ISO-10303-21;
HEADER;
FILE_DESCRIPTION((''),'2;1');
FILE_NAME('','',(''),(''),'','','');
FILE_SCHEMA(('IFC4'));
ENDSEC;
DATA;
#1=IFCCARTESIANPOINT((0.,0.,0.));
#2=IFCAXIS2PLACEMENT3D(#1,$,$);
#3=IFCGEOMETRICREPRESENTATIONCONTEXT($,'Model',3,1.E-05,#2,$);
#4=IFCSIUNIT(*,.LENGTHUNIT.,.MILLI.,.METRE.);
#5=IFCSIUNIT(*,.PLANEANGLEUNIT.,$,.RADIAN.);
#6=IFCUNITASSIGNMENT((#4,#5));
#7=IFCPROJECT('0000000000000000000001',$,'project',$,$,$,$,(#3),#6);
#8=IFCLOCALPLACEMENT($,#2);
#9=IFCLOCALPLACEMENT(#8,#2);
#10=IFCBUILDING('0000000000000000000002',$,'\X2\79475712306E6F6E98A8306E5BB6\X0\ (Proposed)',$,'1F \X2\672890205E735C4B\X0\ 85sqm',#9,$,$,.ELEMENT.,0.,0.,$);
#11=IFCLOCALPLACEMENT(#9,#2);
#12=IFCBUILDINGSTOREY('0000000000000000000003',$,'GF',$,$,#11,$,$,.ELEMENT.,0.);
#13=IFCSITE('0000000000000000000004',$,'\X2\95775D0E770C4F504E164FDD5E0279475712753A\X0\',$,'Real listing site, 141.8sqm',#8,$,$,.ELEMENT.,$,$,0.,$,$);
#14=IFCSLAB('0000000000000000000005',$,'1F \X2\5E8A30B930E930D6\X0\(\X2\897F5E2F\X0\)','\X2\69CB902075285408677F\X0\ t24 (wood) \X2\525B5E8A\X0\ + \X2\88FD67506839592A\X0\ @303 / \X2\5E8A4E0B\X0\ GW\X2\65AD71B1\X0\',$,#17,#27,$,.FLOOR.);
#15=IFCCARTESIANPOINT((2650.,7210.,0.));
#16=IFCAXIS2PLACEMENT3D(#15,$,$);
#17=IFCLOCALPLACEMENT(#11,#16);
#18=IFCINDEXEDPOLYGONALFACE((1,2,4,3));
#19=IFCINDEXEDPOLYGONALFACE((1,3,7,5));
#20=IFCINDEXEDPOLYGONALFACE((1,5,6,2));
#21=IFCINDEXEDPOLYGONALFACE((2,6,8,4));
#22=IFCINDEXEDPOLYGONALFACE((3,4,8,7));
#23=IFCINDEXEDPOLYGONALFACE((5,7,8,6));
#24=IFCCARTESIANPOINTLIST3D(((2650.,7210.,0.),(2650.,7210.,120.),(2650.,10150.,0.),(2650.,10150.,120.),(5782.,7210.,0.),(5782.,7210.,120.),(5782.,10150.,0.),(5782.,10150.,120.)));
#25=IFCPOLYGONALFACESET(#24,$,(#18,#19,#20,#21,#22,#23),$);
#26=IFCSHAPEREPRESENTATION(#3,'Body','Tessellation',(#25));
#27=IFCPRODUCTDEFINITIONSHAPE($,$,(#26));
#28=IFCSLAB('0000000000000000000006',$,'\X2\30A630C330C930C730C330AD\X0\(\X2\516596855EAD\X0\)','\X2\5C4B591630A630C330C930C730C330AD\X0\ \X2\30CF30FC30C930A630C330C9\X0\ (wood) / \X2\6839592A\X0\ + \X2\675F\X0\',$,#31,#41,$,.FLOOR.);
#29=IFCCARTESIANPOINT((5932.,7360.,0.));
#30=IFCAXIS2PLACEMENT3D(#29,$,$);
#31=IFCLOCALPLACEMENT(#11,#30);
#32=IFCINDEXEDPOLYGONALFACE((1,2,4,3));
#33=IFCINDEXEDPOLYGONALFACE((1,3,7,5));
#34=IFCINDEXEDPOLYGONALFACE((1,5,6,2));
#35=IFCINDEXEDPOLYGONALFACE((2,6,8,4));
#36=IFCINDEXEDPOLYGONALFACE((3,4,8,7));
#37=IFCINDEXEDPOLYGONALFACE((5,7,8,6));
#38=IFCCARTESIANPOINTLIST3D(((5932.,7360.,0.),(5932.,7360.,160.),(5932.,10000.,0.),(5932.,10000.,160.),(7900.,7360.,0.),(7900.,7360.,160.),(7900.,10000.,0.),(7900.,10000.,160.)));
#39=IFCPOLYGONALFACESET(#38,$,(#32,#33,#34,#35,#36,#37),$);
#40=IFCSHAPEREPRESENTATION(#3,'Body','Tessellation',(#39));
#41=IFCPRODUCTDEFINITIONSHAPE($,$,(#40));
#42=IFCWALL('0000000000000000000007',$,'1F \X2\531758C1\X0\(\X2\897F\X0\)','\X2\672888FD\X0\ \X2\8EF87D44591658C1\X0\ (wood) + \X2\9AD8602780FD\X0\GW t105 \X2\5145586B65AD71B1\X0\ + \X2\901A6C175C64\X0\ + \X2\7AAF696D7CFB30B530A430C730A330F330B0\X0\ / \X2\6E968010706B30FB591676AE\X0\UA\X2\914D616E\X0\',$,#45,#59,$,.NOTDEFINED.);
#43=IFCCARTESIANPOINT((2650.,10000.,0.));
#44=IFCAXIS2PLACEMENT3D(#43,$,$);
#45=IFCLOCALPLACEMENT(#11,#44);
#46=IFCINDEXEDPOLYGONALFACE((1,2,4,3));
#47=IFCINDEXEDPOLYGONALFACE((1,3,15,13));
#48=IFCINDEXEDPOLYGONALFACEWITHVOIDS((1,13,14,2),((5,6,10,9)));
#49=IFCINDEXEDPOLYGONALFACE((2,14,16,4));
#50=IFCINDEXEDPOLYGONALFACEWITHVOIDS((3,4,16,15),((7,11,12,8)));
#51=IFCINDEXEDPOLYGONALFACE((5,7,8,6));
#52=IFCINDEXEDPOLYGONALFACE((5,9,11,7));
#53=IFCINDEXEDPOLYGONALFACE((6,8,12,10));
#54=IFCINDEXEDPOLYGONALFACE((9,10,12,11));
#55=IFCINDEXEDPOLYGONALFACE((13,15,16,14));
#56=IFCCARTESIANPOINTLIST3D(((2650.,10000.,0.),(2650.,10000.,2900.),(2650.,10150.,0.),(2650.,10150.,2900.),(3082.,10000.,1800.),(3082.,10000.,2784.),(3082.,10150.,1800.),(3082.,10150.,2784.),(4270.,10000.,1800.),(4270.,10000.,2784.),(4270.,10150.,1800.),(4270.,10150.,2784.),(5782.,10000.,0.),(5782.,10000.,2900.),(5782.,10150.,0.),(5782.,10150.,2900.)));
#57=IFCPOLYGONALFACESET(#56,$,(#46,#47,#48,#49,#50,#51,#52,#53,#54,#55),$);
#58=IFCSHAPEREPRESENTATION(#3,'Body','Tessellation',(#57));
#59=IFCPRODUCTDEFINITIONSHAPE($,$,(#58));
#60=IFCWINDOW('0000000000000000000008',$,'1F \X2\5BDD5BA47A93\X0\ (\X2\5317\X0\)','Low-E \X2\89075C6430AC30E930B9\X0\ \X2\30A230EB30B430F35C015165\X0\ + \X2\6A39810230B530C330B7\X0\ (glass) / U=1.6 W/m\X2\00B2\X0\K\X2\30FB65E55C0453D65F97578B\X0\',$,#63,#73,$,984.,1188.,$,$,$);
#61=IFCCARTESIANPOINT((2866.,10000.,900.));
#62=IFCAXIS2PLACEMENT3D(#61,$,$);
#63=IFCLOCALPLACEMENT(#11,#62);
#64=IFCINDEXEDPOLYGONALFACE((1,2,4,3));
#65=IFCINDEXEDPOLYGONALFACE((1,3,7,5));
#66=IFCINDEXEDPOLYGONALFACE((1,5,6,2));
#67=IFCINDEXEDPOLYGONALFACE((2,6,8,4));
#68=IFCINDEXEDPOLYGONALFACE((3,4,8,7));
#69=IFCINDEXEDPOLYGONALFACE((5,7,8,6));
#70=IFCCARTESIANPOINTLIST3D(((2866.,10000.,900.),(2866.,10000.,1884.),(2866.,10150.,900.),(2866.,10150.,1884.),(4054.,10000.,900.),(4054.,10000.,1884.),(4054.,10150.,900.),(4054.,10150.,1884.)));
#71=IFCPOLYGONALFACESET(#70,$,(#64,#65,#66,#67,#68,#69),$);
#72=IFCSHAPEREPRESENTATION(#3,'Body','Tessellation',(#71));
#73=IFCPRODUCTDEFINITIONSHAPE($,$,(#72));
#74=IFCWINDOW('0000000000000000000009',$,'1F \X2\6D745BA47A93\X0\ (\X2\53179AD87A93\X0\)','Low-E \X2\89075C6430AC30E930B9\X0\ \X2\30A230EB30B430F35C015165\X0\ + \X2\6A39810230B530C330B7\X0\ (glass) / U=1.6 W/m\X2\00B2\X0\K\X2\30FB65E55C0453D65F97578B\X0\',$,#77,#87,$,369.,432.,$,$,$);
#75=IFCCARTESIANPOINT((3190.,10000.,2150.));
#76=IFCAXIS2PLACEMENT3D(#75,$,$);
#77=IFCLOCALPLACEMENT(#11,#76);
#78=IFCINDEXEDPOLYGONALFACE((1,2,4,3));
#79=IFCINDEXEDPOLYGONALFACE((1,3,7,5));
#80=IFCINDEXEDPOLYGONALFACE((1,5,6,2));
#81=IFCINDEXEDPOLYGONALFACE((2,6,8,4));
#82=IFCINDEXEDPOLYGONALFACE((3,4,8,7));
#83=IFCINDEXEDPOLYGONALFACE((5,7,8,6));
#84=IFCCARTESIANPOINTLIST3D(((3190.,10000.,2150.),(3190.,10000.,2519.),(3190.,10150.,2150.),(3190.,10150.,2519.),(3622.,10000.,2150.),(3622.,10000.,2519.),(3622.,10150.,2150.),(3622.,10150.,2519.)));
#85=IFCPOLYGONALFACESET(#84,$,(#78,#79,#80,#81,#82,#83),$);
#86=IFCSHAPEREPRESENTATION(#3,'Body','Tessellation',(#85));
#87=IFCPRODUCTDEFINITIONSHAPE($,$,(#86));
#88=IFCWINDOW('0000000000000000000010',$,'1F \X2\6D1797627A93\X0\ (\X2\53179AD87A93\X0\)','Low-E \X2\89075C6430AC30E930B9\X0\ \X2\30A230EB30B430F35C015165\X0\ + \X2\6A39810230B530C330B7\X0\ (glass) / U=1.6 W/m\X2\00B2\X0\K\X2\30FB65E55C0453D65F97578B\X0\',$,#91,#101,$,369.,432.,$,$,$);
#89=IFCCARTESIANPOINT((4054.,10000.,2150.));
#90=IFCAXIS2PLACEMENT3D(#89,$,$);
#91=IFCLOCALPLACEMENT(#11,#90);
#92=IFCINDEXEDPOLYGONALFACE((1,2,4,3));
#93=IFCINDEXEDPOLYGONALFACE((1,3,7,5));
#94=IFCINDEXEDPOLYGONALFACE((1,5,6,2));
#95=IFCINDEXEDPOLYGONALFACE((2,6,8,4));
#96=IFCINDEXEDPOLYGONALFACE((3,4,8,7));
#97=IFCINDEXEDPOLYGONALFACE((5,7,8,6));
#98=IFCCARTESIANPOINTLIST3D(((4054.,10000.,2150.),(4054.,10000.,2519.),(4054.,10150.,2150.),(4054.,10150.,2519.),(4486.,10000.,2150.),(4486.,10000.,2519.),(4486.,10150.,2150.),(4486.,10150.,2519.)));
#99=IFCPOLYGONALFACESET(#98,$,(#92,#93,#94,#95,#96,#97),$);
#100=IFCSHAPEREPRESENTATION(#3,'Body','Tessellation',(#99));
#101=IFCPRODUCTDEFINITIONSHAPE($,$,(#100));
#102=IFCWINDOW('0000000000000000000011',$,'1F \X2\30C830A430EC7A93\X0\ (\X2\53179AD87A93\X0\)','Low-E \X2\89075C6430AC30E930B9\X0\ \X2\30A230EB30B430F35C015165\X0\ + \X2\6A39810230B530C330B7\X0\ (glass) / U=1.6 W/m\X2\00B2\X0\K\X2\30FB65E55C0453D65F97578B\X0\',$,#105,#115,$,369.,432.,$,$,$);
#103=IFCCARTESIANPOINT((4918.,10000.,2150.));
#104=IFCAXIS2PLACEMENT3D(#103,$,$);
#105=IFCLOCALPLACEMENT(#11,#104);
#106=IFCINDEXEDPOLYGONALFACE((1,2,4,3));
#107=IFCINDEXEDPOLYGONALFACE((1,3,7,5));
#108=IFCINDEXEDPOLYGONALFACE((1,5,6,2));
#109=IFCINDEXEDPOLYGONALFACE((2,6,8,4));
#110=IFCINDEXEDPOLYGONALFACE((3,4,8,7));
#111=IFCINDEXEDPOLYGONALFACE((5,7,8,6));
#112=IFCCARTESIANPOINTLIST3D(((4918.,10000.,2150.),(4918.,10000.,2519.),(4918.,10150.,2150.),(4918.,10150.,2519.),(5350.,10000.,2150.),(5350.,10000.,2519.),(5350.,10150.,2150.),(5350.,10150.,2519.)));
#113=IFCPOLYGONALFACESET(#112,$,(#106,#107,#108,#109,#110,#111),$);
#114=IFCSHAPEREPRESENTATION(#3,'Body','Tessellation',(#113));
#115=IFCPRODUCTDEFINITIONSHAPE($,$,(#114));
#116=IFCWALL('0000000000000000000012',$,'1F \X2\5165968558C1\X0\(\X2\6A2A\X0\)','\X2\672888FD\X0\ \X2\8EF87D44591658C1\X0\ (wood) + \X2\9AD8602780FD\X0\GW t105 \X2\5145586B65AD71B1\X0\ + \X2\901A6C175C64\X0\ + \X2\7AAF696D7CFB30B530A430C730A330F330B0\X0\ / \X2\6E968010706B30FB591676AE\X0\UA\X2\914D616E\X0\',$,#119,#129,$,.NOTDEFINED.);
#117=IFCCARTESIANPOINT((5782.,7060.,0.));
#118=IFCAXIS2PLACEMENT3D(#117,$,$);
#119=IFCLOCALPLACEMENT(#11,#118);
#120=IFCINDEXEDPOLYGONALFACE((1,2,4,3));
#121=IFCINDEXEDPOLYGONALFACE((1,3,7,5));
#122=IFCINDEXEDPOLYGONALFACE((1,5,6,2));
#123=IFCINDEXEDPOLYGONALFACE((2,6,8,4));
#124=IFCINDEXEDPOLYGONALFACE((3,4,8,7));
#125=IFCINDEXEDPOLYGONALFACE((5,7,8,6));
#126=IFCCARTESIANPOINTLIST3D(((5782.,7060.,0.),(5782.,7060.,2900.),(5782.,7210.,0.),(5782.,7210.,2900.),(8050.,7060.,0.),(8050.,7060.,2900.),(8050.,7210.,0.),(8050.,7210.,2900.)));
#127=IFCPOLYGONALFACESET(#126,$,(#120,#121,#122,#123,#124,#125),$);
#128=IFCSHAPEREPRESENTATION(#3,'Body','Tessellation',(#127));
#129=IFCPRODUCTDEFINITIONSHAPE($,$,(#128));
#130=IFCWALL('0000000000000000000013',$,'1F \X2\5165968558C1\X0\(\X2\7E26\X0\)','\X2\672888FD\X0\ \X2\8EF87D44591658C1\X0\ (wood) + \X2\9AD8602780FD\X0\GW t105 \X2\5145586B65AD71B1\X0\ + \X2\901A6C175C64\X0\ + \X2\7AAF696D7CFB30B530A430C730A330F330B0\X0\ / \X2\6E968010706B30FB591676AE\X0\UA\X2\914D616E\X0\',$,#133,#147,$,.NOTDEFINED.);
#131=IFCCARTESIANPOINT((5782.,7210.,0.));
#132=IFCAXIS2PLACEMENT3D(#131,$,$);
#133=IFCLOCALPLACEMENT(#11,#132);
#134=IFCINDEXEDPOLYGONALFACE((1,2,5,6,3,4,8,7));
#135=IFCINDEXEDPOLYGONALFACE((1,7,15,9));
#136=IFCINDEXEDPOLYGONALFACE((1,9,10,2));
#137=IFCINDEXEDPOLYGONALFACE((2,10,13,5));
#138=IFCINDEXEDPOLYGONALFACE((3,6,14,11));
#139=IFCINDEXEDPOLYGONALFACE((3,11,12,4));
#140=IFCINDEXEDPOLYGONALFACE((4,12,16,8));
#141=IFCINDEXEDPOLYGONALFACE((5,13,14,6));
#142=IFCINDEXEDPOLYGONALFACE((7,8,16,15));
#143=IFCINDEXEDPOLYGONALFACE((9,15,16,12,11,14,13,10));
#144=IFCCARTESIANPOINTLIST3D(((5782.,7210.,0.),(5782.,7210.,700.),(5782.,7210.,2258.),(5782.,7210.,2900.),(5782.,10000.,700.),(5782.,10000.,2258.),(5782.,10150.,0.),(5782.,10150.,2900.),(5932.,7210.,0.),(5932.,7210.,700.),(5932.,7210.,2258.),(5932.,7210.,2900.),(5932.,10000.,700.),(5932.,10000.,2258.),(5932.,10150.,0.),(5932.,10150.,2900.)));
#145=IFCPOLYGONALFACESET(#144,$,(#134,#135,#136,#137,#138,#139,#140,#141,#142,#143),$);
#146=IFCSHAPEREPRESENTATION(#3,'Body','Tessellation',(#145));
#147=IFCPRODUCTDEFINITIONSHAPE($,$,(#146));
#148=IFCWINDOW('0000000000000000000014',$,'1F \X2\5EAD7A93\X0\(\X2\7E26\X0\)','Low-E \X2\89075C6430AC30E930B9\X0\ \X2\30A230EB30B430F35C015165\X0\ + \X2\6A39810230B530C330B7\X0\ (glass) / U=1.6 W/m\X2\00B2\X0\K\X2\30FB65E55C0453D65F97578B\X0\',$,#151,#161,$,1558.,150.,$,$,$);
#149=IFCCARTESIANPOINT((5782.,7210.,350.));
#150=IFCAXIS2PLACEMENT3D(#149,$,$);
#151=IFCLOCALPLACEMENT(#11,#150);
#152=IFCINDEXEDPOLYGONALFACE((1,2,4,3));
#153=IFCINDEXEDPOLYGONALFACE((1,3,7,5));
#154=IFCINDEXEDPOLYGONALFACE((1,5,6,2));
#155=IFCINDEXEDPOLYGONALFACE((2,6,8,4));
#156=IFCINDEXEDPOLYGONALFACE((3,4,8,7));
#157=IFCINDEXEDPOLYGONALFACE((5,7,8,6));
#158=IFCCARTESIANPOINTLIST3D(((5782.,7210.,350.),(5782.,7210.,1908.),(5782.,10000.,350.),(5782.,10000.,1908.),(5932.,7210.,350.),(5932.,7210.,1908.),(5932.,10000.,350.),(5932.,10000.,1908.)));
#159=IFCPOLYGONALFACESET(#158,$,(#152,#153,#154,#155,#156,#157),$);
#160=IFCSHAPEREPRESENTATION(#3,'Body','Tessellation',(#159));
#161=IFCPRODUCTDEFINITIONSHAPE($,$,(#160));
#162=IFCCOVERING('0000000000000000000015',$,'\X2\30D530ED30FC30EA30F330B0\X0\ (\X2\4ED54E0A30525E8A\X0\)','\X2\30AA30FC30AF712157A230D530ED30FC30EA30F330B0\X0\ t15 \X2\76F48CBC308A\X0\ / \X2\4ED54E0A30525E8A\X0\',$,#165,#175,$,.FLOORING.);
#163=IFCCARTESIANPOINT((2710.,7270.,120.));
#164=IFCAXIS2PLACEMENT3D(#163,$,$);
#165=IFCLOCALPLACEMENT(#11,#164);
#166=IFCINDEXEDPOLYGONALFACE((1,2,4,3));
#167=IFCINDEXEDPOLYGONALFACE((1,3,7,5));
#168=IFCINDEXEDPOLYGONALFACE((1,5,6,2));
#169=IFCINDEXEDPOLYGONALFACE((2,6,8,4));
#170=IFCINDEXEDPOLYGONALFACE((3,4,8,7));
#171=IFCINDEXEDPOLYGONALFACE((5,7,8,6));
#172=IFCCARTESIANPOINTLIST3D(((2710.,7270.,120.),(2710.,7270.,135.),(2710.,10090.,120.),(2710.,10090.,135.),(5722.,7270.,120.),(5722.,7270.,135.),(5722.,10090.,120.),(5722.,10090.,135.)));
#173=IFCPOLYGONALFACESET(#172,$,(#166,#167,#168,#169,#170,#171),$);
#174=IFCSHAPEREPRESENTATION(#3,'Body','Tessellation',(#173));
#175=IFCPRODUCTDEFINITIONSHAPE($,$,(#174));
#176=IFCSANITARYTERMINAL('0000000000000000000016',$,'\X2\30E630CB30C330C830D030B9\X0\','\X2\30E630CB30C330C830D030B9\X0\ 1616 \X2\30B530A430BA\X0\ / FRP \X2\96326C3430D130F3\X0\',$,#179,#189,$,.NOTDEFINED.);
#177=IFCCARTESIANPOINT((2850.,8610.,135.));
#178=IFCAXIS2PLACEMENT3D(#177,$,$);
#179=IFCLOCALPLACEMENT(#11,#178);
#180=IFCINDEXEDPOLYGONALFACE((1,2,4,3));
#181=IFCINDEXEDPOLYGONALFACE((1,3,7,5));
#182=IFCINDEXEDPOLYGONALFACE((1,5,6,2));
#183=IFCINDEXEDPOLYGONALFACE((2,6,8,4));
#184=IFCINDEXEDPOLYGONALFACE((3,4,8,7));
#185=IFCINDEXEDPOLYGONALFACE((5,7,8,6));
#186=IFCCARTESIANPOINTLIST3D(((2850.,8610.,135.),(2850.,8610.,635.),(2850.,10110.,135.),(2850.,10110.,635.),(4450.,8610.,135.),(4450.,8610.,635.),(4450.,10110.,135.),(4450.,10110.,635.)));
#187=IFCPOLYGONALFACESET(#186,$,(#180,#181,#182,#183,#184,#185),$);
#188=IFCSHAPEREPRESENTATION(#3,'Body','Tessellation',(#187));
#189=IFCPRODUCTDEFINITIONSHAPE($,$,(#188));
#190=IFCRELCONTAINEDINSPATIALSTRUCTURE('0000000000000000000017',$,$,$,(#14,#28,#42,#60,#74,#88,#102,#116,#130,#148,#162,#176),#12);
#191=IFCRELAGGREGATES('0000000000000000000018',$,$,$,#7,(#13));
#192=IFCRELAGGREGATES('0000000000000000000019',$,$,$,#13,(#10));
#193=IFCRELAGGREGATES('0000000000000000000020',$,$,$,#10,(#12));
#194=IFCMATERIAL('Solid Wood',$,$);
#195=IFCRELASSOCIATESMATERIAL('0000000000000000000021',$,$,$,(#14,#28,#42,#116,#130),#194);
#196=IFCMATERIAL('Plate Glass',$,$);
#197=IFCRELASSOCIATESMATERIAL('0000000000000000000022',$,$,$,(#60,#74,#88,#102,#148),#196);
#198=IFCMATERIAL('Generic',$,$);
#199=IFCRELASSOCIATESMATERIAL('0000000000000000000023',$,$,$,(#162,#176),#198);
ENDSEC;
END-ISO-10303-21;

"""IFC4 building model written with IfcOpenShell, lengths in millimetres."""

from ifc_helpers import new_model, si_unit, frame, frame_2d, origin, place, context, project, spatial, rectangle, extrude, material, element, fill, save


model = new_model("IFC4")

# Units and contexts
model_context = context("Model", 3, precision=1e-05, world=origin())
ifc_project = project(units=[si_unit("LENGTHUNIT", "METRE", prefix="MILLI"), si_unit("PLANEANGLEUNIT", "RADIAN")], contexts=[model_context])

# Site, building, storey
site_placement = place(None, origin())
site = spatial("IfcSite", under=ifc_project, at=site_placement, Name="長崎県佐世保市祇園町", ObjectType="Real listing site, 141.8sqm", CompositionType="ELEMENT", RefElevation=0.0)
building_placement = place(site_placement, origin())
building = spatial("IfcBuilding", under=site, at=building_placement, Name="祇園の潮風の家 (Proposed)", ObjectType="1F 木造平屋 85sqm", CompositionType="ELEMENT", ElevationOfRefHeight=0.0, ElevationOfTerrain=0.0)
storey_placement = place(building_placement, origin())
storey = spatial("IfcBuildingStorey", under=building, at=storey_placement, Name="GF", CompositionType="ELEMENT", Elevation=0.0)

# Slabs
ifc_material_1 = material(Name="Solid Wood")
slab_1_placement = place(storey_placement, frame((2650.0, 7210.0, 0.0)))
element("IfcSlab", 1, at=slab_1_placement, inside=storey, material=ifc_material_1, Name="1F 床スラブ(西帯)", Description="構造用合板 t24 (wood) 剛床 + 製材根太 @303 / 床下 GW断熱", PredefinedType="FLOOR", context=model_context, shape_type="SweptSolid", body=[
    extrude(rectangle(XDim=3132.0, YDim=2940.0, at=frame_2d((1566.0, 1470.0))), frame((2650.0, 7210.0, 0.0)), (0.0, 0.0, 1.0), 120.0),
])
slab_2_placement = place(storey_placement, frame((5932.0, 7360.0, 0.0)))
element("IfcSlab", 2, at=slab_2_placement, inside=storey, material=ifc_material_1, Name="ウッドデッキ(入隅庭)", Description="屋外ウッドデッキ ハードウッド (wood) / 根太 + 束", PredefinedType="FLOOR", context=model_context, shape_type="SweptSolid", body=[
    extrude(rectangle(XDim=1968.0, YDim=2640.0, at=frame_2d((984.0, 1320.0))), frame((5932.0, 7360.0, 0.0)), (0.0, 0.0, 1.0), 160.0),
])

# Wall, openings, windows
wall_1_placement = place(storey_placement, frame((2650.0, 10000.0, 0.0)))
wall_1 = element("IfcWall", 3, at=wall_1_placement, inside=storey, material=ifc_material_1, Name="1F 北壁(西)", Description="木製 軸組外壁 (wood) + 高性能GW t105 充填断熱 + 通気層 + 窯業系サイディング / 準耐火・外皮UA配慮", PredefinedType="NOTDEFINED", context=model_context, shape_type="SweptSolid", body=[
    extrude(rectangle(XDim=3132.0, YDim=150.0, at=frame_2d((1566.0, 75.0))), frame((2650.0, 10000.0, 0.0)), (0.0, 0.0, 1.0), 2900.0),
])
opening_1_placement = place(storey_placement, frame((2866.0, 10000.0, 900.0)))
opening_1 = element("IfcOpeningElement", 4, at=opening_1_placement, cuts=wall_1, PredefinedType="NOTDEFINED", context=model_context, shape_type="SweptSolid", body=[
    extrude(rectangle(XDim=1188.0, YDim=150.0, at=frame_2d((594.0, 75.0))), frame((2866.0, 10000.0, 900.0)), (0.0, 0.0, 1.0), 984.0),
])
opening_2_placement = place(storey_placement, frame((3190.0, 10000.0, 2150.0)))
opening_2 = element("IfcOpeningElement", 5, at=opening_2_placement, cuts=wall_1, PredefinedType="NOTDEFINED", context=model_context, shape_type="SweptSolid", body=[
    extrude(rectangle(XDim=432.0, YDim=150.0, at=frame_2d((216.0, 75.0))), frame((3190.0, 10000.0, 2150.0)), (0.0, 0.0, 1.0), 369.0),
])
opening_3_placement = place(storey_placement, frame((4054.0, 10000.0, 2150.0)))
opening_3 = element("IfcOpeningElement", 6, at=opening_3_placement, cuts=wall_1, PredefinedType="NOTDEFINED", context=model_context, shape_type="SweptSolid", body=[
    extrude(rectangle(XDim=432.0, YDim=150.0, at=frame_2d((216.0, 75.0))), frame((4054.0, 10000.0, 2150.0)), (0.0, 0.0, 1.0), 369.0),
])
opening_4_placement = place(storey_placement, frame((4918.0, 10000.0, 2150.0)))
opening_4 = element("IfcOpeningElement", 7, at=opening_4_placement, cuts=wall_1, PredefinedType="NOTDEFINED", context=model_context, shape_type="SweptSolid", body=[
    extrude(rectangle(XDim=432.0, YDim=150.0, at=frame_2d((216.0, 75.0))), frame((4918.0, 10000.0, 2150.0)), (0.0, 0.0, 1.0), 369.0),
])
ifc_material_2 = material(Name="Plate Glass")
window_1_placement = place(storey_placement, frame((2866.0, 10000.0, 900.0)))
window_1 = element("IfcWindow", 8, at=window_1_placement, inside=storey, material=ifc_material_2, Name="1F 寝室窓 (北)", Description="Low-E 複層ガラス アルゴン封入 + 樹脂サッシ (glass) / U=1.6 W/m²K・日射取得型", OverallHeight=984.0, OverallWidth=1188.0, context=model_context, shape_type="SweptSolid", body=[
    extrude(rectangle(XDim=1188.0, YDim=150.0, at=frame_2d((594.0, 75.0))), frame((2866.0, 10000.0, 900.0)), (0.0, 0.0, 1.0), 984.0),
])
fill(opening_1, window_1)
window_2_placement = place(storey_placement, frame((3190.0, 10000.0, 2150.0)))
window_2 = element("IfcWindow", 9, at=window_2_placement, inside=storey, material=ifc_material_2, Name="1F 浴室窓 (北高窓)", Description="Low-E 複層ガラス アルゴン封入 + 樹脂サッシ (glass) / U=1.6 W/m²K・日射取得型", OverallHeight=369.0, OverallWidth=432.0, context=model_context, shape_type="SweptSolid", body=[
    extrude(rectangle(XDim=432.0, YDim=150.0, at=frame_2d((216.0, 75.0))), frame((3190.0, 10000.0, 2150.0)), (0.0, 0.0, 1.0), 369.0),
])
fill(opening_2, window_2)
window_3_placement = place(storey_placement, frame((4054.0, 10000.0, 2150.0)))
window_3 = element("IfcWindow", 10, at=window_3_placement, inside=storey, material=ifc_material_2, Name="1F 洗面窓 (北高窓)", Description="Low-E 複層ガラス アルゴン封入 + 樹脂サッシ (glass) / U=1.6 W/m²K・日射取得型", OverallHeight=369.0, OverallWidth=432.0, context=model_context, shape_type="SweptSolid", body=[
    extrude(rectangle(XDim=432.0, YDim=150.0, at=frame_2d((216.0, 75.0))), frame((4054.0, 10000.0, 2150.0)), (0.0, 0.0, 1.0), 369.0),
])
fill(opening_3, window_3)
window_4_placement = place(storey_placement, frame((4918.0, 10000.0, 2150.0)))
window_4 = element("IfcWindow", 11, at=window_4_placement, inside=storey, material=ifc_material_2, Name="1F トイレ窓 (北高窓)", Description="Low-E 複層ガラス アルゴン封入 + 樹脂サッシ (glass) / U=1.6 W/m²K・日射取得型", OverallHeight=369.0, OverallWidth=432.0, context=model_context, shape_type="SweptSolid", body=[
    extrude(rectangle(XDim=432.0, YDim=150.0, at=frame_2d((216.0, 75.0))), frame((4918.0, 10000.0, 2150.0)), (0.0, 0.0, 1.0), 369.0),
])
fill(opening_4, window_4)

# Wall
wall_2_placement = place(storey_placement, frame((5782.0, 7060.0, 0.0)))
element("IfcWall", 12, at=wall_2_placement, inside=storey, material=ifc_material_1, Name="1F 入隅壁(横)", Description="木製 軸組外壁 (wood) + 高性能GW t105 充填断熱 + 通気層 + 窯業系サイディング / 準耐火・外皮UA配慮", PredefinedType="NOTDEFINED", context=model_context, shape_type="SweptSolid", body=[
    extrude(rectangle(XDim=2268.0, YDim=150.0, at=frame_2d((1134.0, 75.0))), frame((5782.0, 7060.0, 0.0)), (0.0, 0.0, 1.0), 2900.0),
])

# Wall, opening, window
wall_3_placement = place(storey_placement, frame((5782.0, 7210.0, 0.0)))
wall_3 = element("IfcWall", 13, at=wall_3_placement, inside=storey, material=ifc_material_1, Name="1F 入隅壁(縦)", Description="木製 軸組外壁 (wood) + 高性能GW t105 充填断熱 + 通気層 + 窯業系サイディング / 準耐火・外皮UA配慮", PredefinedType="NOTDEFINED", context=model_context, shape_type="SweptSolid", body=[
    extrude(rectangle(XDim=150.0, YDim=2940.0, at=frame_2d((75.0, 1470.0))), frame((5782.0, 7210.0, 0.0)), (0.0, 0.0, 1.0), 2900.0),
])
opening_5_placement = place(storey_placement, frame((5782.0, 7210.0, 350.0)))
opening_5 = element("IfcOpeningElement", 14, at=opening_5_placement, cuts=wall_3, PredefinedType="NOTDEFINED", context=model_context, shape_type="SweptSolid", body=[
    extrude(rectangle(XDim=150.0, YDim=2790.0, at=frame_2d((75.0, 1395.0))), frame((5782.0, 7210.0, 350.0)), (0.0, 0.0, 1.0), 1558.0),
])
window_5_placement = place(storey_placement, frame((5782.0, 7210.0, 350.0)))
window_5 = element("IfcWindow", 15, at=window_5_placement, inside=storey, material=ifc_material_2, Name="1F 庭窓(縦)", Description="Low-E 複層ガラス アルゴン封入 + 樹脂サッシ (glass) / U=1.6 W/m²K・日射取得型", OverallHeight=1558.0, OverallWidth=150.0, context=model_context, shape_type="SweptSolid", body=[
    extrude(rectangle(XDim=150.0, YDim=2790.0, at=frame_2d((75.0, 1395.0))), frame((5782.0, 7210.0, 350.0)), (0.0, 0.0, 1.0), 1558.0),
])
fill(opening_5, window_5)

# Covering
ifc_material_3 = material(Name="Generic")
covering_placement = place(storey_placement, frame((2710.0, 7270.0, 120.0)))
element("IfcCovering", 16, at=covering_placement, inside=storey, material=ifc_material_3, Name="フローリング (仕上げ床)", Description="オーク無垢フローリング t15 直貼り / 仕上げ床", PredefinedType="FLOORING", context=model_context, shape_type="SweptSolid", body=[
    extrude(rectangle(XDim=3012.0, YDim=2820.0, at=frame_2d((1506.0, 1410.0))), frame((2710.0, 7270.0, 120.0)), (0.0, 0.0, 1.0), 15.0),
])

# Sanitary terminal
sanitary_terminal_1_placement = place(storey_placement, frame((2850.0, 8610.0, 135.0)))
element("IfcSanitaryTerminal", 17, at=sanitary_terminal_1_placement, inside=storey, material=ifc_material_3, Name="ユニットバス", Description="ユニットバス 1616 サイズ / FRP 防水パン", PredefinedType="NOTDEFINED", context=model_context, shape_type="SweptSolid", body=[
    extrude(rectangle(XDim=1600.0, YDim=1500.0, at=frame_2d((800.0, 750.0))), frame((2850.0, 8610.0, 135.0)), (0.0, 0.0, 1.0), 500.0),
])

save(model, "model.ifc")
